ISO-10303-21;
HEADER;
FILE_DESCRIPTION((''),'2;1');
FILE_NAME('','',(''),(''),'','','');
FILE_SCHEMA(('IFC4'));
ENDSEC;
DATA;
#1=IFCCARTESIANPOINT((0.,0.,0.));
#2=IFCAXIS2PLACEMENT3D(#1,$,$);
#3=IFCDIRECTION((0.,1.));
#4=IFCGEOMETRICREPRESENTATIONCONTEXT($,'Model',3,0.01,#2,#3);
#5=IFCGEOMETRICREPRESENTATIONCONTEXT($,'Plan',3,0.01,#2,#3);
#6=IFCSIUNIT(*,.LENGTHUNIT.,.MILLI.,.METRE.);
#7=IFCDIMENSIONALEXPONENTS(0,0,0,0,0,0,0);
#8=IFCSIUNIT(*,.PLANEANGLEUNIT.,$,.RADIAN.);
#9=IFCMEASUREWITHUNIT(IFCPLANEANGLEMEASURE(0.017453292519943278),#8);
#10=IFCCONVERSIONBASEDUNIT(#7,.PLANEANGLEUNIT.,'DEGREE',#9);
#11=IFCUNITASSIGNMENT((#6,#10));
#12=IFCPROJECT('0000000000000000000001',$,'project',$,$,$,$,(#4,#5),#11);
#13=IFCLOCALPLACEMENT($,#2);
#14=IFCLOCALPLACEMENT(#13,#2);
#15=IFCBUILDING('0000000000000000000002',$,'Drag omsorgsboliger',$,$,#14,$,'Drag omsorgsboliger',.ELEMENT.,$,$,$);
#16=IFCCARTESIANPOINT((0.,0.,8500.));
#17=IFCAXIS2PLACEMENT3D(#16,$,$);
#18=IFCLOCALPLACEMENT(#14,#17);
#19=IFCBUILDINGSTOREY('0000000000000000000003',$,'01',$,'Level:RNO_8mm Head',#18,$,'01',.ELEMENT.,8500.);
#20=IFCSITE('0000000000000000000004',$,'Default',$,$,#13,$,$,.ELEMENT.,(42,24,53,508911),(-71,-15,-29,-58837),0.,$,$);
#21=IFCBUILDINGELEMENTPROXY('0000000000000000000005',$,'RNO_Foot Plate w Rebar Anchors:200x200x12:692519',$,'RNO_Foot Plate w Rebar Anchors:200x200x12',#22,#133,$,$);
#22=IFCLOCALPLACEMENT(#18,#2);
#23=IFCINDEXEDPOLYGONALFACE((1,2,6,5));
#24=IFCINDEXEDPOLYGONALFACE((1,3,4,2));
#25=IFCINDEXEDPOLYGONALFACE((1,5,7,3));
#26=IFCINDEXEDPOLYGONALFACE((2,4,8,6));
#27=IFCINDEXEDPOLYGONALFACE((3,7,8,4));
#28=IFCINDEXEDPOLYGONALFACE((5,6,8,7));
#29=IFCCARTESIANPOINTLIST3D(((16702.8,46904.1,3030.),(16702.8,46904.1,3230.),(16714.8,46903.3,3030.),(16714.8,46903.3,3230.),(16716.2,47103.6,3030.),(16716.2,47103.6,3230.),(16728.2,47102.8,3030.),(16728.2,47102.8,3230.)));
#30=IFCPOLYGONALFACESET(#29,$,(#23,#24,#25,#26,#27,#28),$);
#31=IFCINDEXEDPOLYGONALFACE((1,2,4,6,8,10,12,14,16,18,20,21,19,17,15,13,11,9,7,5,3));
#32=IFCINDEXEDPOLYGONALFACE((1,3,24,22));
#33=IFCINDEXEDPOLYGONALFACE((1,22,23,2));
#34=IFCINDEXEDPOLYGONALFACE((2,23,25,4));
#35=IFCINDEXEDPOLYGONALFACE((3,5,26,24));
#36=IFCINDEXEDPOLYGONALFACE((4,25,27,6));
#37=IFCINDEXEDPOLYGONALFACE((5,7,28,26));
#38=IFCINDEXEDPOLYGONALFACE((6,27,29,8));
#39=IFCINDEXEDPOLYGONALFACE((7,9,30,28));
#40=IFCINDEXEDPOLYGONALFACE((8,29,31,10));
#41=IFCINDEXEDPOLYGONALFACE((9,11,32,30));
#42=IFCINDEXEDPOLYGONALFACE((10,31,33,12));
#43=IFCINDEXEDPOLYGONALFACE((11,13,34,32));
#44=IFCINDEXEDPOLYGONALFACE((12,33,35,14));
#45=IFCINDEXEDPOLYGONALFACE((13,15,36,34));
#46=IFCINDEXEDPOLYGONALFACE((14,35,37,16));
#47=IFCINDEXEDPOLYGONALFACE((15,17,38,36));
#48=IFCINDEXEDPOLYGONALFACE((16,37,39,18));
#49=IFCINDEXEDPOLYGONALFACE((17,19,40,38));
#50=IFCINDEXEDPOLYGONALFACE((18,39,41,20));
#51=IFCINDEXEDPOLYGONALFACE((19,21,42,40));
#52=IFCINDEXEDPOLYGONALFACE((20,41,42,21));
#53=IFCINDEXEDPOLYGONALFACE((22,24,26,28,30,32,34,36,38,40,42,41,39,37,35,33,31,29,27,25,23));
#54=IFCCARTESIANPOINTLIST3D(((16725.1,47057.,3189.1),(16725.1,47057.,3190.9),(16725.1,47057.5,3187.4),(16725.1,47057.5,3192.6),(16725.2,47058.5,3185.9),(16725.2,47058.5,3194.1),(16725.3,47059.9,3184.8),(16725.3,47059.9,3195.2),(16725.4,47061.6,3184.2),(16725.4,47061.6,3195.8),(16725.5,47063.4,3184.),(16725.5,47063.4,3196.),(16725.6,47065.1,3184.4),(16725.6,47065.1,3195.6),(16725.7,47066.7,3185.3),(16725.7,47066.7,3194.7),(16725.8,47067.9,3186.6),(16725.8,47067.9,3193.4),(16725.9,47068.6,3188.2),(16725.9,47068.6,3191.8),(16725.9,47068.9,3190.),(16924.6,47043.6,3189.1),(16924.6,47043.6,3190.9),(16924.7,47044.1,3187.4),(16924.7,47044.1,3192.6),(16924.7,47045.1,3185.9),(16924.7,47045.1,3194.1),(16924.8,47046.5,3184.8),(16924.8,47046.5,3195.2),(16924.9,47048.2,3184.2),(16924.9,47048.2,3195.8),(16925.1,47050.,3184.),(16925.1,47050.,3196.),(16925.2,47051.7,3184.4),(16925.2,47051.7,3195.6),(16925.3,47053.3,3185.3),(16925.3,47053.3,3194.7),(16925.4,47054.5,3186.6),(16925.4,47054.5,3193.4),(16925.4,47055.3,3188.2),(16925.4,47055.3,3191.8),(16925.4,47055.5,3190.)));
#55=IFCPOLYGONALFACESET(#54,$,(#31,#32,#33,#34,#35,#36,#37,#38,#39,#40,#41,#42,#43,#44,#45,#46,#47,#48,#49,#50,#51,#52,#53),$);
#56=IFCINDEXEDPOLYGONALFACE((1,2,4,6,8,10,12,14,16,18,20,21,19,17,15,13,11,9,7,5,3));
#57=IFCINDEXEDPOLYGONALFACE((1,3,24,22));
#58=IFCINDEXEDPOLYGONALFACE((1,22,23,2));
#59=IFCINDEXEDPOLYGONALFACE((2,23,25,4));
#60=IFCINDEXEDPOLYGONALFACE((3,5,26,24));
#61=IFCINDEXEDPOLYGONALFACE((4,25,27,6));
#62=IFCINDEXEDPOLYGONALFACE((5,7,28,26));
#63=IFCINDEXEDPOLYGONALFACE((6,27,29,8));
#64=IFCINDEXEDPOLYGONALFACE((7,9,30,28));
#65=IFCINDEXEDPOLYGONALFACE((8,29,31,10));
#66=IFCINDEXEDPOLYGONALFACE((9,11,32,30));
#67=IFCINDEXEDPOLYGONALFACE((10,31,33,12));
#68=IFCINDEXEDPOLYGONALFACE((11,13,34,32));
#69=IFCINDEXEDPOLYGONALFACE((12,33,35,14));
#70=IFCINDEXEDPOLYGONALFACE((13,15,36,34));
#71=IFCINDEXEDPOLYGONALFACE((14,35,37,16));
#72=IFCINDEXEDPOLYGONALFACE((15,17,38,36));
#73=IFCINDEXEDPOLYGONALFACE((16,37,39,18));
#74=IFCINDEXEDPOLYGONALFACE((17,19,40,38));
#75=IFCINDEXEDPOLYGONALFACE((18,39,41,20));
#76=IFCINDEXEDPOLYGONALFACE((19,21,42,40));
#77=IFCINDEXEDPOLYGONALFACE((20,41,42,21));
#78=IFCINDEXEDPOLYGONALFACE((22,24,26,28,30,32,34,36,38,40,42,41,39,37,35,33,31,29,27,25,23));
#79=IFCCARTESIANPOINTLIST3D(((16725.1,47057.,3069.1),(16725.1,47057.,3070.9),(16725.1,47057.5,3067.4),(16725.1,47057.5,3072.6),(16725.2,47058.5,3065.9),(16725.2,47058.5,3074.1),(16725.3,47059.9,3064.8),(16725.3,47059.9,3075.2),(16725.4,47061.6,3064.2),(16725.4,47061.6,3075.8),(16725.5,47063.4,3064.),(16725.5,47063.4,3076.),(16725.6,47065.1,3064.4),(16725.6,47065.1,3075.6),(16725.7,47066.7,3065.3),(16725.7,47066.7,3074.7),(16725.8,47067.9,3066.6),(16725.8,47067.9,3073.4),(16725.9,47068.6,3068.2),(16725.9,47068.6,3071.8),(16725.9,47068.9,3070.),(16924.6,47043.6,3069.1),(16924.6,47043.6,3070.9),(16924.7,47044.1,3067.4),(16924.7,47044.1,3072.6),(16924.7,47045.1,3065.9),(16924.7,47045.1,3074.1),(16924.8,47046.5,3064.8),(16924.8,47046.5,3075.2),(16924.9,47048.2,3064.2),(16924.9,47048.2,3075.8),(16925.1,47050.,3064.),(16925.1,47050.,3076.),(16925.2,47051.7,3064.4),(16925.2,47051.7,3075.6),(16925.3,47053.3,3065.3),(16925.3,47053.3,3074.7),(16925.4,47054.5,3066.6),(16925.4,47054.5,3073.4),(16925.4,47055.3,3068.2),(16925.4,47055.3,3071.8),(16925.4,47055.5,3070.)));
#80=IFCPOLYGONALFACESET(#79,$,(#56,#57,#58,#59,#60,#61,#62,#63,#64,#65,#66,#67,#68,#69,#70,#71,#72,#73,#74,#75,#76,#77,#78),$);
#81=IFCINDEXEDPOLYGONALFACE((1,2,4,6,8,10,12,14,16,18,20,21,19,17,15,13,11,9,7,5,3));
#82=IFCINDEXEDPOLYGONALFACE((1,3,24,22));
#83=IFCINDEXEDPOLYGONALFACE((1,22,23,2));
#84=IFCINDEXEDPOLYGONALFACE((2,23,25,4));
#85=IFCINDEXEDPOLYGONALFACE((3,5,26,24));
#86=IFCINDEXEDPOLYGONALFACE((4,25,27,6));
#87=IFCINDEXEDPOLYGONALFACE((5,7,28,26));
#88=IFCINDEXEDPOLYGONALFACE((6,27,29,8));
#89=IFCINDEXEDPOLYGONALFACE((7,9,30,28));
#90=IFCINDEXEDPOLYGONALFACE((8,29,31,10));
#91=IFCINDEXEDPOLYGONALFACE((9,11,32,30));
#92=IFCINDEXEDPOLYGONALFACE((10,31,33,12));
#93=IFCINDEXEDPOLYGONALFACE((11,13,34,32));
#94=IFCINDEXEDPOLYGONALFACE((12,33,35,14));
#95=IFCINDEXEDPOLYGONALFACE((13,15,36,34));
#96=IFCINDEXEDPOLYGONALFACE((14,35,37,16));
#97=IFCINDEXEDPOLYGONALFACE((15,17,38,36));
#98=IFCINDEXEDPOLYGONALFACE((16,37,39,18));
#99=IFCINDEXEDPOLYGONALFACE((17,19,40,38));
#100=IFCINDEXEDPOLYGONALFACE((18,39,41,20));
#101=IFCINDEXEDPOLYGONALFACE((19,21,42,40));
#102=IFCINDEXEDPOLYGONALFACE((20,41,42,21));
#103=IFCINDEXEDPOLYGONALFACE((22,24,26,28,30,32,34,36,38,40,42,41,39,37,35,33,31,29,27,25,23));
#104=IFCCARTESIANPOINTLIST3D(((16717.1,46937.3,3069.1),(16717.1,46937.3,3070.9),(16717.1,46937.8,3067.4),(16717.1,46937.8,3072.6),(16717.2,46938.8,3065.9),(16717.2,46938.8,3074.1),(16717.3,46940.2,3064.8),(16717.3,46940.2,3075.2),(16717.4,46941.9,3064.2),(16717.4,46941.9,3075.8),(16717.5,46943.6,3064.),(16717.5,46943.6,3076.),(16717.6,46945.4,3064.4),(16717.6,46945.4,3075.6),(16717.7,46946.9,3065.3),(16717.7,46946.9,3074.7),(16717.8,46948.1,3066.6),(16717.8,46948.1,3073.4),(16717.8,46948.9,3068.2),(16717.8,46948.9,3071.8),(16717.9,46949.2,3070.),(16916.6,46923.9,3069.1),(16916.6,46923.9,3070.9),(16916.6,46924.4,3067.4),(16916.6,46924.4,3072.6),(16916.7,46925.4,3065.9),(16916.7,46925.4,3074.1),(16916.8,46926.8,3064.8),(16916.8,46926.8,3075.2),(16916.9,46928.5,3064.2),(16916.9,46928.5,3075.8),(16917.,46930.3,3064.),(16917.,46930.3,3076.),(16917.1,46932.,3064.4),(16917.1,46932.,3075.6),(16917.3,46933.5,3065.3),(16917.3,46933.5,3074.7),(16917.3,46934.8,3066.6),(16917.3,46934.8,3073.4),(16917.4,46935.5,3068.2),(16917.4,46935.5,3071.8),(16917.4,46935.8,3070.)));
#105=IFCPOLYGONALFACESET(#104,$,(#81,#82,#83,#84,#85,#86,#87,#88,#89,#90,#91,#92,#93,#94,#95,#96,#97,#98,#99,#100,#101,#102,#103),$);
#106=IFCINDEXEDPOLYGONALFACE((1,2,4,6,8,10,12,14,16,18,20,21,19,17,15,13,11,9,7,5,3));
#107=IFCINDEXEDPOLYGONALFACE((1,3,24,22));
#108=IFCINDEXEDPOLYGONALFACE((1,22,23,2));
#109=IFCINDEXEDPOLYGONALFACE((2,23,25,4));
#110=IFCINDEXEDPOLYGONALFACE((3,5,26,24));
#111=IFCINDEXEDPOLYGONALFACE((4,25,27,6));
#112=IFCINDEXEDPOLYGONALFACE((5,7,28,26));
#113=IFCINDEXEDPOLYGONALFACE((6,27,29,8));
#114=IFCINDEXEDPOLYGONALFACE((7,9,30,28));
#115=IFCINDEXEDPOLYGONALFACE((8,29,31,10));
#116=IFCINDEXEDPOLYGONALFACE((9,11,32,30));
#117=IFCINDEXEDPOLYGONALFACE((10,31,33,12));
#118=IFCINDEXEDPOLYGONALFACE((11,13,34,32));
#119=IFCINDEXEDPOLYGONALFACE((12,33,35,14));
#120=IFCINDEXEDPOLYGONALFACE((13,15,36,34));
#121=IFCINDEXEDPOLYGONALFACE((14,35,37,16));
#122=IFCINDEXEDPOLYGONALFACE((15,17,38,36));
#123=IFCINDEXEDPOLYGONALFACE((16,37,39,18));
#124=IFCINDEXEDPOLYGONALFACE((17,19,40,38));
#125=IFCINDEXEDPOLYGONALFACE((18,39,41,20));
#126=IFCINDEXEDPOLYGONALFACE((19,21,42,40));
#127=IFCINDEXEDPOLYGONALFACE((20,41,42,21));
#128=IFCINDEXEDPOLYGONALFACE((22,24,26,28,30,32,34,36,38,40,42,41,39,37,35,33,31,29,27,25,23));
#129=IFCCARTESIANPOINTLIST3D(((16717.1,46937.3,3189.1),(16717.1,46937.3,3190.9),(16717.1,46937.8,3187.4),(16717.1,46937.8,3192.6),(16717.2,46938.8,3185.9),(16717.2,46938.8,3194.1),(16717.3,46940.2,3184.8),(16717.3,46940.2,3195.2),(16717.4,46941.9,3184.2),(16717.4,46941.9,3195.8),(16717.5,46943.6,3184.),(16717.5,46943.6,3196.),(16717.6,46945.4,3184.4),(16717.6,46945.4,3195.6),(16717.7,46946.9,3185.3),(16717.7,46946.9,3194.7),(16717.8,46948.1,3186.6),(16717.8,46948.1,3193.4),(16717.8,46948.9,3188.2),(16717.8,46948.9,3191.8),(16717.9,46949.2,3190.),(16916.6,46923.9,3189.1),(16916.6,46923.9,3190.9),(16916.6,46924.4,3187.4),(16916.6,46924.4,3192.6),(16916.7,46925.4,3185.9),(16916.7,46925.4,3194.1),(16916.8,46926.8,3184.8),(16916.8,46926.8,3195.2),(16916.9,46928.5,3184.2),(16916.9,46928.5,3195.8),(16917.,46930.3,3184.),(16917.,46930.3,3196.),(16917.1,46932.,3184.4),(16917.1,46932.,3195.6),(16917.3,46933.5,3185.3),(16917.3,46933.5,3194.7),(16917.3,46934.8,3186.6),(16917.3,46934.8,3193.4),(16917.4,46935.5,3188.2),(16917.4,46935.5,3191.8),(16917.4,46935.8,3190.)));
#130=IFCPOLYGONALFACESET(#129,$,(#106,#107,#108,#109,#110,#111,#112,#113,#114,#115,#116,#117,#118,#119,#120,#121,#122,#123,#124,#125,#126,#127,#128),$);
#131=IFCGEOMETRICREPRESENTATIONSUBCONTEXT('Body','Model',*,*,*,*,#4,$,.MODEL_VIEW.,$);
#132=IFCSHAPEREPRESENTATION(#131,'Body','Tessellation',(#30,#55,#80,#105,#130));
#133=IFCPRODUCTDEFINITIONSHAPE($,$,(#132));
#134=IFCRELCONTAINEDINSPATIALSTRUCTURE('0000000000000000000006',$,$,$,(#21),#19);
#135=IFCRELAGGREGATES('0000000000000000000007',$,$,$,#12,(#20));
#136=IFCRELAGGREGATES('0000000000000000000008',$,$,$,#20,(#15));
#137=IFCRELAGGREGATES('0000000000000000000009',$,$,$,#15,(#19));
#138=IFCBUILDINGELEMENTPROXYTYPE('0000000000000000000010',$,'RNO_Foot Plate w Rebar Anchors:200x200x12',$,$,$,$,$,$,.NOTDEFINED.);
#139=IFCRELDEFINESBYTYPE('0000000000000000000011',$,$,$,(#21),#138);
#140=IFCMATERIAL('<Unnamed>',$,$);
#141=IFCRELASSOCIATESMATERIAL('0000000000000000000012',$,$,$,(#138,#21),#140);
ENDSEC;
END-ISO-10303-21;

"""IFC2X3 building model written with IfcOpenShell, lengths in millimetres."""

from ifc_helpers import new_model, entity, si_unit, converted_unit, direction, frame, frame_2d, origin, origin_2d_with_axis, place, context, subcontext, project, spatial, rectangle, circle, extrude, source, transform, mapped, material, type_object, type_shapes, element, save


model = new_model("IFC2X3")

# Units and contexts
model_context = context("Model", 3, precision=0.01, world=origin(), true_north=direction((0.0, 1.0)))
plan_context = context("Plan", 3, precision=0.01, world=origin(), true_north=direction((0.0, 1.0)))
body_context = subcontext(model_context, "Body", "Model", "MODEL_VIEW")
ifc_project = project(units=[si_unit("LENGTHUNIT", "METRE", prefix="MILLI"), converted_unit("PLANEANGLEUNIT", "DEGREE", entity("IfcPlaneAngleMeasure", 0.017453292519943278), si_unit("PLANEANGLEUNIT", "RADIAN"), dimensions=[0, 0, 0, 0, 0, 0, 0])], contexts=[model_context, plan_context])

# Site, building, storey
site_placement = place(None, origin())
site = spatial("IfcSite", under=ifc_project, at=site_placement, Name="Default", CompositionType="ELEMENT", RefLatitude=(42, 24, 53, 508911), RefLongitude=(-71, -15, -29, -58837), RefElevation=0.0)
building_placement = place(site_placement, origin())
building = spatial("IfcBuilding", under=site, at=building_placement, Name="Drag omsorgsboliger", LongName="Drag omsorgsboliger", CompositionType="ELEMENT")
storey_placement = place(building_placement, frame((0.0, 0.0, 8500.0)))
storey = spatial("IfcBuildingStorey", under=building, at=storey_placement, Name="01", ObjectType="Level:RNO_8mm Head", LongName="01", CompositionType="ELEMENT", Elevation=8500.0)

# Building element proxy
ifc_material_1 = material(Name="<Unnamed>")
building_element_proxy_type_1 = type_object("IfcBuildingElementProxyType", Name="RNO_Foot Plate w Rebar Anchors:200x200x12", PredefinedType="NOTDEFINED", material=ifc_material_1)
shared_shape_1 = source(origin(), body_context, "Body", "SweptSolid", [
    extrude(rectangle(XDim=200.0, YDim=200.0, at=origin_2d_with_axis()), frame((-90.0, 20.0, -12.0), z_axis=(0.0, 0.0, 1.0), x_axis=(-1.0, 0.0, 0.0)), (0.0, 0.0, 1.0), 12.0),
    extrude(circle(Radius=6.0, at=frame_2d((0.0, 0.0), x_axis=(1.0, 0.0))), frame((-30.0, -40.0, -212.0)), (0.0, 0.0, 1.0), 200.0),
    extrude(circle(Radius=6.0, at=frame_2d((0.0, 0.0), x_axis=(1.0, 0.0))), frame((-30.0, 80.0, -212.0)), (0.0, 0.0, 1.0), 200.0),
    extrude(circle(Radius=6.0, at=origin_2d_with_axis()), frame((-150.0, 80.0, -212.0)), (0.0, 0.0, 1.0), 200.0),
    extrude(circle(Radius=6.0, at=frame_2d((0.0, 0.0), x_axis=(1.0, 0.0))), frame((-150.0, -40.0, -212.0)), (0.0, 0.0, 1.0), 200.0),
])
type_shapes(building_element_proxy_type_1, [shared_shape_1])
proxy_1_placement = place(storey_placement, frame((16715.5, 47093.7, 3150.0), z_axis=(-0.997758, 0.066923, 0.0), x_axis=(0.066923, 0.997758, 0.0)))
element("IfcBuildingElementProxy", 1, at=proxy_1_placement, inside=storey, type_object=building_element_proxy_type_1, material=ifc_material_1, Name="RNO_Foot Plate w Rebar Anchors:200x200x12:692519", ObjectType="RNO_Foot Plate w Rebar Anchors:200x200x12", context=body_context, shape_type="MappedRepresentation", body=[
    mapped(shared_shape_1, transform((0.0, 0.0, 0.0), scale=1.0)),
])

save(model, "model.ifc")
